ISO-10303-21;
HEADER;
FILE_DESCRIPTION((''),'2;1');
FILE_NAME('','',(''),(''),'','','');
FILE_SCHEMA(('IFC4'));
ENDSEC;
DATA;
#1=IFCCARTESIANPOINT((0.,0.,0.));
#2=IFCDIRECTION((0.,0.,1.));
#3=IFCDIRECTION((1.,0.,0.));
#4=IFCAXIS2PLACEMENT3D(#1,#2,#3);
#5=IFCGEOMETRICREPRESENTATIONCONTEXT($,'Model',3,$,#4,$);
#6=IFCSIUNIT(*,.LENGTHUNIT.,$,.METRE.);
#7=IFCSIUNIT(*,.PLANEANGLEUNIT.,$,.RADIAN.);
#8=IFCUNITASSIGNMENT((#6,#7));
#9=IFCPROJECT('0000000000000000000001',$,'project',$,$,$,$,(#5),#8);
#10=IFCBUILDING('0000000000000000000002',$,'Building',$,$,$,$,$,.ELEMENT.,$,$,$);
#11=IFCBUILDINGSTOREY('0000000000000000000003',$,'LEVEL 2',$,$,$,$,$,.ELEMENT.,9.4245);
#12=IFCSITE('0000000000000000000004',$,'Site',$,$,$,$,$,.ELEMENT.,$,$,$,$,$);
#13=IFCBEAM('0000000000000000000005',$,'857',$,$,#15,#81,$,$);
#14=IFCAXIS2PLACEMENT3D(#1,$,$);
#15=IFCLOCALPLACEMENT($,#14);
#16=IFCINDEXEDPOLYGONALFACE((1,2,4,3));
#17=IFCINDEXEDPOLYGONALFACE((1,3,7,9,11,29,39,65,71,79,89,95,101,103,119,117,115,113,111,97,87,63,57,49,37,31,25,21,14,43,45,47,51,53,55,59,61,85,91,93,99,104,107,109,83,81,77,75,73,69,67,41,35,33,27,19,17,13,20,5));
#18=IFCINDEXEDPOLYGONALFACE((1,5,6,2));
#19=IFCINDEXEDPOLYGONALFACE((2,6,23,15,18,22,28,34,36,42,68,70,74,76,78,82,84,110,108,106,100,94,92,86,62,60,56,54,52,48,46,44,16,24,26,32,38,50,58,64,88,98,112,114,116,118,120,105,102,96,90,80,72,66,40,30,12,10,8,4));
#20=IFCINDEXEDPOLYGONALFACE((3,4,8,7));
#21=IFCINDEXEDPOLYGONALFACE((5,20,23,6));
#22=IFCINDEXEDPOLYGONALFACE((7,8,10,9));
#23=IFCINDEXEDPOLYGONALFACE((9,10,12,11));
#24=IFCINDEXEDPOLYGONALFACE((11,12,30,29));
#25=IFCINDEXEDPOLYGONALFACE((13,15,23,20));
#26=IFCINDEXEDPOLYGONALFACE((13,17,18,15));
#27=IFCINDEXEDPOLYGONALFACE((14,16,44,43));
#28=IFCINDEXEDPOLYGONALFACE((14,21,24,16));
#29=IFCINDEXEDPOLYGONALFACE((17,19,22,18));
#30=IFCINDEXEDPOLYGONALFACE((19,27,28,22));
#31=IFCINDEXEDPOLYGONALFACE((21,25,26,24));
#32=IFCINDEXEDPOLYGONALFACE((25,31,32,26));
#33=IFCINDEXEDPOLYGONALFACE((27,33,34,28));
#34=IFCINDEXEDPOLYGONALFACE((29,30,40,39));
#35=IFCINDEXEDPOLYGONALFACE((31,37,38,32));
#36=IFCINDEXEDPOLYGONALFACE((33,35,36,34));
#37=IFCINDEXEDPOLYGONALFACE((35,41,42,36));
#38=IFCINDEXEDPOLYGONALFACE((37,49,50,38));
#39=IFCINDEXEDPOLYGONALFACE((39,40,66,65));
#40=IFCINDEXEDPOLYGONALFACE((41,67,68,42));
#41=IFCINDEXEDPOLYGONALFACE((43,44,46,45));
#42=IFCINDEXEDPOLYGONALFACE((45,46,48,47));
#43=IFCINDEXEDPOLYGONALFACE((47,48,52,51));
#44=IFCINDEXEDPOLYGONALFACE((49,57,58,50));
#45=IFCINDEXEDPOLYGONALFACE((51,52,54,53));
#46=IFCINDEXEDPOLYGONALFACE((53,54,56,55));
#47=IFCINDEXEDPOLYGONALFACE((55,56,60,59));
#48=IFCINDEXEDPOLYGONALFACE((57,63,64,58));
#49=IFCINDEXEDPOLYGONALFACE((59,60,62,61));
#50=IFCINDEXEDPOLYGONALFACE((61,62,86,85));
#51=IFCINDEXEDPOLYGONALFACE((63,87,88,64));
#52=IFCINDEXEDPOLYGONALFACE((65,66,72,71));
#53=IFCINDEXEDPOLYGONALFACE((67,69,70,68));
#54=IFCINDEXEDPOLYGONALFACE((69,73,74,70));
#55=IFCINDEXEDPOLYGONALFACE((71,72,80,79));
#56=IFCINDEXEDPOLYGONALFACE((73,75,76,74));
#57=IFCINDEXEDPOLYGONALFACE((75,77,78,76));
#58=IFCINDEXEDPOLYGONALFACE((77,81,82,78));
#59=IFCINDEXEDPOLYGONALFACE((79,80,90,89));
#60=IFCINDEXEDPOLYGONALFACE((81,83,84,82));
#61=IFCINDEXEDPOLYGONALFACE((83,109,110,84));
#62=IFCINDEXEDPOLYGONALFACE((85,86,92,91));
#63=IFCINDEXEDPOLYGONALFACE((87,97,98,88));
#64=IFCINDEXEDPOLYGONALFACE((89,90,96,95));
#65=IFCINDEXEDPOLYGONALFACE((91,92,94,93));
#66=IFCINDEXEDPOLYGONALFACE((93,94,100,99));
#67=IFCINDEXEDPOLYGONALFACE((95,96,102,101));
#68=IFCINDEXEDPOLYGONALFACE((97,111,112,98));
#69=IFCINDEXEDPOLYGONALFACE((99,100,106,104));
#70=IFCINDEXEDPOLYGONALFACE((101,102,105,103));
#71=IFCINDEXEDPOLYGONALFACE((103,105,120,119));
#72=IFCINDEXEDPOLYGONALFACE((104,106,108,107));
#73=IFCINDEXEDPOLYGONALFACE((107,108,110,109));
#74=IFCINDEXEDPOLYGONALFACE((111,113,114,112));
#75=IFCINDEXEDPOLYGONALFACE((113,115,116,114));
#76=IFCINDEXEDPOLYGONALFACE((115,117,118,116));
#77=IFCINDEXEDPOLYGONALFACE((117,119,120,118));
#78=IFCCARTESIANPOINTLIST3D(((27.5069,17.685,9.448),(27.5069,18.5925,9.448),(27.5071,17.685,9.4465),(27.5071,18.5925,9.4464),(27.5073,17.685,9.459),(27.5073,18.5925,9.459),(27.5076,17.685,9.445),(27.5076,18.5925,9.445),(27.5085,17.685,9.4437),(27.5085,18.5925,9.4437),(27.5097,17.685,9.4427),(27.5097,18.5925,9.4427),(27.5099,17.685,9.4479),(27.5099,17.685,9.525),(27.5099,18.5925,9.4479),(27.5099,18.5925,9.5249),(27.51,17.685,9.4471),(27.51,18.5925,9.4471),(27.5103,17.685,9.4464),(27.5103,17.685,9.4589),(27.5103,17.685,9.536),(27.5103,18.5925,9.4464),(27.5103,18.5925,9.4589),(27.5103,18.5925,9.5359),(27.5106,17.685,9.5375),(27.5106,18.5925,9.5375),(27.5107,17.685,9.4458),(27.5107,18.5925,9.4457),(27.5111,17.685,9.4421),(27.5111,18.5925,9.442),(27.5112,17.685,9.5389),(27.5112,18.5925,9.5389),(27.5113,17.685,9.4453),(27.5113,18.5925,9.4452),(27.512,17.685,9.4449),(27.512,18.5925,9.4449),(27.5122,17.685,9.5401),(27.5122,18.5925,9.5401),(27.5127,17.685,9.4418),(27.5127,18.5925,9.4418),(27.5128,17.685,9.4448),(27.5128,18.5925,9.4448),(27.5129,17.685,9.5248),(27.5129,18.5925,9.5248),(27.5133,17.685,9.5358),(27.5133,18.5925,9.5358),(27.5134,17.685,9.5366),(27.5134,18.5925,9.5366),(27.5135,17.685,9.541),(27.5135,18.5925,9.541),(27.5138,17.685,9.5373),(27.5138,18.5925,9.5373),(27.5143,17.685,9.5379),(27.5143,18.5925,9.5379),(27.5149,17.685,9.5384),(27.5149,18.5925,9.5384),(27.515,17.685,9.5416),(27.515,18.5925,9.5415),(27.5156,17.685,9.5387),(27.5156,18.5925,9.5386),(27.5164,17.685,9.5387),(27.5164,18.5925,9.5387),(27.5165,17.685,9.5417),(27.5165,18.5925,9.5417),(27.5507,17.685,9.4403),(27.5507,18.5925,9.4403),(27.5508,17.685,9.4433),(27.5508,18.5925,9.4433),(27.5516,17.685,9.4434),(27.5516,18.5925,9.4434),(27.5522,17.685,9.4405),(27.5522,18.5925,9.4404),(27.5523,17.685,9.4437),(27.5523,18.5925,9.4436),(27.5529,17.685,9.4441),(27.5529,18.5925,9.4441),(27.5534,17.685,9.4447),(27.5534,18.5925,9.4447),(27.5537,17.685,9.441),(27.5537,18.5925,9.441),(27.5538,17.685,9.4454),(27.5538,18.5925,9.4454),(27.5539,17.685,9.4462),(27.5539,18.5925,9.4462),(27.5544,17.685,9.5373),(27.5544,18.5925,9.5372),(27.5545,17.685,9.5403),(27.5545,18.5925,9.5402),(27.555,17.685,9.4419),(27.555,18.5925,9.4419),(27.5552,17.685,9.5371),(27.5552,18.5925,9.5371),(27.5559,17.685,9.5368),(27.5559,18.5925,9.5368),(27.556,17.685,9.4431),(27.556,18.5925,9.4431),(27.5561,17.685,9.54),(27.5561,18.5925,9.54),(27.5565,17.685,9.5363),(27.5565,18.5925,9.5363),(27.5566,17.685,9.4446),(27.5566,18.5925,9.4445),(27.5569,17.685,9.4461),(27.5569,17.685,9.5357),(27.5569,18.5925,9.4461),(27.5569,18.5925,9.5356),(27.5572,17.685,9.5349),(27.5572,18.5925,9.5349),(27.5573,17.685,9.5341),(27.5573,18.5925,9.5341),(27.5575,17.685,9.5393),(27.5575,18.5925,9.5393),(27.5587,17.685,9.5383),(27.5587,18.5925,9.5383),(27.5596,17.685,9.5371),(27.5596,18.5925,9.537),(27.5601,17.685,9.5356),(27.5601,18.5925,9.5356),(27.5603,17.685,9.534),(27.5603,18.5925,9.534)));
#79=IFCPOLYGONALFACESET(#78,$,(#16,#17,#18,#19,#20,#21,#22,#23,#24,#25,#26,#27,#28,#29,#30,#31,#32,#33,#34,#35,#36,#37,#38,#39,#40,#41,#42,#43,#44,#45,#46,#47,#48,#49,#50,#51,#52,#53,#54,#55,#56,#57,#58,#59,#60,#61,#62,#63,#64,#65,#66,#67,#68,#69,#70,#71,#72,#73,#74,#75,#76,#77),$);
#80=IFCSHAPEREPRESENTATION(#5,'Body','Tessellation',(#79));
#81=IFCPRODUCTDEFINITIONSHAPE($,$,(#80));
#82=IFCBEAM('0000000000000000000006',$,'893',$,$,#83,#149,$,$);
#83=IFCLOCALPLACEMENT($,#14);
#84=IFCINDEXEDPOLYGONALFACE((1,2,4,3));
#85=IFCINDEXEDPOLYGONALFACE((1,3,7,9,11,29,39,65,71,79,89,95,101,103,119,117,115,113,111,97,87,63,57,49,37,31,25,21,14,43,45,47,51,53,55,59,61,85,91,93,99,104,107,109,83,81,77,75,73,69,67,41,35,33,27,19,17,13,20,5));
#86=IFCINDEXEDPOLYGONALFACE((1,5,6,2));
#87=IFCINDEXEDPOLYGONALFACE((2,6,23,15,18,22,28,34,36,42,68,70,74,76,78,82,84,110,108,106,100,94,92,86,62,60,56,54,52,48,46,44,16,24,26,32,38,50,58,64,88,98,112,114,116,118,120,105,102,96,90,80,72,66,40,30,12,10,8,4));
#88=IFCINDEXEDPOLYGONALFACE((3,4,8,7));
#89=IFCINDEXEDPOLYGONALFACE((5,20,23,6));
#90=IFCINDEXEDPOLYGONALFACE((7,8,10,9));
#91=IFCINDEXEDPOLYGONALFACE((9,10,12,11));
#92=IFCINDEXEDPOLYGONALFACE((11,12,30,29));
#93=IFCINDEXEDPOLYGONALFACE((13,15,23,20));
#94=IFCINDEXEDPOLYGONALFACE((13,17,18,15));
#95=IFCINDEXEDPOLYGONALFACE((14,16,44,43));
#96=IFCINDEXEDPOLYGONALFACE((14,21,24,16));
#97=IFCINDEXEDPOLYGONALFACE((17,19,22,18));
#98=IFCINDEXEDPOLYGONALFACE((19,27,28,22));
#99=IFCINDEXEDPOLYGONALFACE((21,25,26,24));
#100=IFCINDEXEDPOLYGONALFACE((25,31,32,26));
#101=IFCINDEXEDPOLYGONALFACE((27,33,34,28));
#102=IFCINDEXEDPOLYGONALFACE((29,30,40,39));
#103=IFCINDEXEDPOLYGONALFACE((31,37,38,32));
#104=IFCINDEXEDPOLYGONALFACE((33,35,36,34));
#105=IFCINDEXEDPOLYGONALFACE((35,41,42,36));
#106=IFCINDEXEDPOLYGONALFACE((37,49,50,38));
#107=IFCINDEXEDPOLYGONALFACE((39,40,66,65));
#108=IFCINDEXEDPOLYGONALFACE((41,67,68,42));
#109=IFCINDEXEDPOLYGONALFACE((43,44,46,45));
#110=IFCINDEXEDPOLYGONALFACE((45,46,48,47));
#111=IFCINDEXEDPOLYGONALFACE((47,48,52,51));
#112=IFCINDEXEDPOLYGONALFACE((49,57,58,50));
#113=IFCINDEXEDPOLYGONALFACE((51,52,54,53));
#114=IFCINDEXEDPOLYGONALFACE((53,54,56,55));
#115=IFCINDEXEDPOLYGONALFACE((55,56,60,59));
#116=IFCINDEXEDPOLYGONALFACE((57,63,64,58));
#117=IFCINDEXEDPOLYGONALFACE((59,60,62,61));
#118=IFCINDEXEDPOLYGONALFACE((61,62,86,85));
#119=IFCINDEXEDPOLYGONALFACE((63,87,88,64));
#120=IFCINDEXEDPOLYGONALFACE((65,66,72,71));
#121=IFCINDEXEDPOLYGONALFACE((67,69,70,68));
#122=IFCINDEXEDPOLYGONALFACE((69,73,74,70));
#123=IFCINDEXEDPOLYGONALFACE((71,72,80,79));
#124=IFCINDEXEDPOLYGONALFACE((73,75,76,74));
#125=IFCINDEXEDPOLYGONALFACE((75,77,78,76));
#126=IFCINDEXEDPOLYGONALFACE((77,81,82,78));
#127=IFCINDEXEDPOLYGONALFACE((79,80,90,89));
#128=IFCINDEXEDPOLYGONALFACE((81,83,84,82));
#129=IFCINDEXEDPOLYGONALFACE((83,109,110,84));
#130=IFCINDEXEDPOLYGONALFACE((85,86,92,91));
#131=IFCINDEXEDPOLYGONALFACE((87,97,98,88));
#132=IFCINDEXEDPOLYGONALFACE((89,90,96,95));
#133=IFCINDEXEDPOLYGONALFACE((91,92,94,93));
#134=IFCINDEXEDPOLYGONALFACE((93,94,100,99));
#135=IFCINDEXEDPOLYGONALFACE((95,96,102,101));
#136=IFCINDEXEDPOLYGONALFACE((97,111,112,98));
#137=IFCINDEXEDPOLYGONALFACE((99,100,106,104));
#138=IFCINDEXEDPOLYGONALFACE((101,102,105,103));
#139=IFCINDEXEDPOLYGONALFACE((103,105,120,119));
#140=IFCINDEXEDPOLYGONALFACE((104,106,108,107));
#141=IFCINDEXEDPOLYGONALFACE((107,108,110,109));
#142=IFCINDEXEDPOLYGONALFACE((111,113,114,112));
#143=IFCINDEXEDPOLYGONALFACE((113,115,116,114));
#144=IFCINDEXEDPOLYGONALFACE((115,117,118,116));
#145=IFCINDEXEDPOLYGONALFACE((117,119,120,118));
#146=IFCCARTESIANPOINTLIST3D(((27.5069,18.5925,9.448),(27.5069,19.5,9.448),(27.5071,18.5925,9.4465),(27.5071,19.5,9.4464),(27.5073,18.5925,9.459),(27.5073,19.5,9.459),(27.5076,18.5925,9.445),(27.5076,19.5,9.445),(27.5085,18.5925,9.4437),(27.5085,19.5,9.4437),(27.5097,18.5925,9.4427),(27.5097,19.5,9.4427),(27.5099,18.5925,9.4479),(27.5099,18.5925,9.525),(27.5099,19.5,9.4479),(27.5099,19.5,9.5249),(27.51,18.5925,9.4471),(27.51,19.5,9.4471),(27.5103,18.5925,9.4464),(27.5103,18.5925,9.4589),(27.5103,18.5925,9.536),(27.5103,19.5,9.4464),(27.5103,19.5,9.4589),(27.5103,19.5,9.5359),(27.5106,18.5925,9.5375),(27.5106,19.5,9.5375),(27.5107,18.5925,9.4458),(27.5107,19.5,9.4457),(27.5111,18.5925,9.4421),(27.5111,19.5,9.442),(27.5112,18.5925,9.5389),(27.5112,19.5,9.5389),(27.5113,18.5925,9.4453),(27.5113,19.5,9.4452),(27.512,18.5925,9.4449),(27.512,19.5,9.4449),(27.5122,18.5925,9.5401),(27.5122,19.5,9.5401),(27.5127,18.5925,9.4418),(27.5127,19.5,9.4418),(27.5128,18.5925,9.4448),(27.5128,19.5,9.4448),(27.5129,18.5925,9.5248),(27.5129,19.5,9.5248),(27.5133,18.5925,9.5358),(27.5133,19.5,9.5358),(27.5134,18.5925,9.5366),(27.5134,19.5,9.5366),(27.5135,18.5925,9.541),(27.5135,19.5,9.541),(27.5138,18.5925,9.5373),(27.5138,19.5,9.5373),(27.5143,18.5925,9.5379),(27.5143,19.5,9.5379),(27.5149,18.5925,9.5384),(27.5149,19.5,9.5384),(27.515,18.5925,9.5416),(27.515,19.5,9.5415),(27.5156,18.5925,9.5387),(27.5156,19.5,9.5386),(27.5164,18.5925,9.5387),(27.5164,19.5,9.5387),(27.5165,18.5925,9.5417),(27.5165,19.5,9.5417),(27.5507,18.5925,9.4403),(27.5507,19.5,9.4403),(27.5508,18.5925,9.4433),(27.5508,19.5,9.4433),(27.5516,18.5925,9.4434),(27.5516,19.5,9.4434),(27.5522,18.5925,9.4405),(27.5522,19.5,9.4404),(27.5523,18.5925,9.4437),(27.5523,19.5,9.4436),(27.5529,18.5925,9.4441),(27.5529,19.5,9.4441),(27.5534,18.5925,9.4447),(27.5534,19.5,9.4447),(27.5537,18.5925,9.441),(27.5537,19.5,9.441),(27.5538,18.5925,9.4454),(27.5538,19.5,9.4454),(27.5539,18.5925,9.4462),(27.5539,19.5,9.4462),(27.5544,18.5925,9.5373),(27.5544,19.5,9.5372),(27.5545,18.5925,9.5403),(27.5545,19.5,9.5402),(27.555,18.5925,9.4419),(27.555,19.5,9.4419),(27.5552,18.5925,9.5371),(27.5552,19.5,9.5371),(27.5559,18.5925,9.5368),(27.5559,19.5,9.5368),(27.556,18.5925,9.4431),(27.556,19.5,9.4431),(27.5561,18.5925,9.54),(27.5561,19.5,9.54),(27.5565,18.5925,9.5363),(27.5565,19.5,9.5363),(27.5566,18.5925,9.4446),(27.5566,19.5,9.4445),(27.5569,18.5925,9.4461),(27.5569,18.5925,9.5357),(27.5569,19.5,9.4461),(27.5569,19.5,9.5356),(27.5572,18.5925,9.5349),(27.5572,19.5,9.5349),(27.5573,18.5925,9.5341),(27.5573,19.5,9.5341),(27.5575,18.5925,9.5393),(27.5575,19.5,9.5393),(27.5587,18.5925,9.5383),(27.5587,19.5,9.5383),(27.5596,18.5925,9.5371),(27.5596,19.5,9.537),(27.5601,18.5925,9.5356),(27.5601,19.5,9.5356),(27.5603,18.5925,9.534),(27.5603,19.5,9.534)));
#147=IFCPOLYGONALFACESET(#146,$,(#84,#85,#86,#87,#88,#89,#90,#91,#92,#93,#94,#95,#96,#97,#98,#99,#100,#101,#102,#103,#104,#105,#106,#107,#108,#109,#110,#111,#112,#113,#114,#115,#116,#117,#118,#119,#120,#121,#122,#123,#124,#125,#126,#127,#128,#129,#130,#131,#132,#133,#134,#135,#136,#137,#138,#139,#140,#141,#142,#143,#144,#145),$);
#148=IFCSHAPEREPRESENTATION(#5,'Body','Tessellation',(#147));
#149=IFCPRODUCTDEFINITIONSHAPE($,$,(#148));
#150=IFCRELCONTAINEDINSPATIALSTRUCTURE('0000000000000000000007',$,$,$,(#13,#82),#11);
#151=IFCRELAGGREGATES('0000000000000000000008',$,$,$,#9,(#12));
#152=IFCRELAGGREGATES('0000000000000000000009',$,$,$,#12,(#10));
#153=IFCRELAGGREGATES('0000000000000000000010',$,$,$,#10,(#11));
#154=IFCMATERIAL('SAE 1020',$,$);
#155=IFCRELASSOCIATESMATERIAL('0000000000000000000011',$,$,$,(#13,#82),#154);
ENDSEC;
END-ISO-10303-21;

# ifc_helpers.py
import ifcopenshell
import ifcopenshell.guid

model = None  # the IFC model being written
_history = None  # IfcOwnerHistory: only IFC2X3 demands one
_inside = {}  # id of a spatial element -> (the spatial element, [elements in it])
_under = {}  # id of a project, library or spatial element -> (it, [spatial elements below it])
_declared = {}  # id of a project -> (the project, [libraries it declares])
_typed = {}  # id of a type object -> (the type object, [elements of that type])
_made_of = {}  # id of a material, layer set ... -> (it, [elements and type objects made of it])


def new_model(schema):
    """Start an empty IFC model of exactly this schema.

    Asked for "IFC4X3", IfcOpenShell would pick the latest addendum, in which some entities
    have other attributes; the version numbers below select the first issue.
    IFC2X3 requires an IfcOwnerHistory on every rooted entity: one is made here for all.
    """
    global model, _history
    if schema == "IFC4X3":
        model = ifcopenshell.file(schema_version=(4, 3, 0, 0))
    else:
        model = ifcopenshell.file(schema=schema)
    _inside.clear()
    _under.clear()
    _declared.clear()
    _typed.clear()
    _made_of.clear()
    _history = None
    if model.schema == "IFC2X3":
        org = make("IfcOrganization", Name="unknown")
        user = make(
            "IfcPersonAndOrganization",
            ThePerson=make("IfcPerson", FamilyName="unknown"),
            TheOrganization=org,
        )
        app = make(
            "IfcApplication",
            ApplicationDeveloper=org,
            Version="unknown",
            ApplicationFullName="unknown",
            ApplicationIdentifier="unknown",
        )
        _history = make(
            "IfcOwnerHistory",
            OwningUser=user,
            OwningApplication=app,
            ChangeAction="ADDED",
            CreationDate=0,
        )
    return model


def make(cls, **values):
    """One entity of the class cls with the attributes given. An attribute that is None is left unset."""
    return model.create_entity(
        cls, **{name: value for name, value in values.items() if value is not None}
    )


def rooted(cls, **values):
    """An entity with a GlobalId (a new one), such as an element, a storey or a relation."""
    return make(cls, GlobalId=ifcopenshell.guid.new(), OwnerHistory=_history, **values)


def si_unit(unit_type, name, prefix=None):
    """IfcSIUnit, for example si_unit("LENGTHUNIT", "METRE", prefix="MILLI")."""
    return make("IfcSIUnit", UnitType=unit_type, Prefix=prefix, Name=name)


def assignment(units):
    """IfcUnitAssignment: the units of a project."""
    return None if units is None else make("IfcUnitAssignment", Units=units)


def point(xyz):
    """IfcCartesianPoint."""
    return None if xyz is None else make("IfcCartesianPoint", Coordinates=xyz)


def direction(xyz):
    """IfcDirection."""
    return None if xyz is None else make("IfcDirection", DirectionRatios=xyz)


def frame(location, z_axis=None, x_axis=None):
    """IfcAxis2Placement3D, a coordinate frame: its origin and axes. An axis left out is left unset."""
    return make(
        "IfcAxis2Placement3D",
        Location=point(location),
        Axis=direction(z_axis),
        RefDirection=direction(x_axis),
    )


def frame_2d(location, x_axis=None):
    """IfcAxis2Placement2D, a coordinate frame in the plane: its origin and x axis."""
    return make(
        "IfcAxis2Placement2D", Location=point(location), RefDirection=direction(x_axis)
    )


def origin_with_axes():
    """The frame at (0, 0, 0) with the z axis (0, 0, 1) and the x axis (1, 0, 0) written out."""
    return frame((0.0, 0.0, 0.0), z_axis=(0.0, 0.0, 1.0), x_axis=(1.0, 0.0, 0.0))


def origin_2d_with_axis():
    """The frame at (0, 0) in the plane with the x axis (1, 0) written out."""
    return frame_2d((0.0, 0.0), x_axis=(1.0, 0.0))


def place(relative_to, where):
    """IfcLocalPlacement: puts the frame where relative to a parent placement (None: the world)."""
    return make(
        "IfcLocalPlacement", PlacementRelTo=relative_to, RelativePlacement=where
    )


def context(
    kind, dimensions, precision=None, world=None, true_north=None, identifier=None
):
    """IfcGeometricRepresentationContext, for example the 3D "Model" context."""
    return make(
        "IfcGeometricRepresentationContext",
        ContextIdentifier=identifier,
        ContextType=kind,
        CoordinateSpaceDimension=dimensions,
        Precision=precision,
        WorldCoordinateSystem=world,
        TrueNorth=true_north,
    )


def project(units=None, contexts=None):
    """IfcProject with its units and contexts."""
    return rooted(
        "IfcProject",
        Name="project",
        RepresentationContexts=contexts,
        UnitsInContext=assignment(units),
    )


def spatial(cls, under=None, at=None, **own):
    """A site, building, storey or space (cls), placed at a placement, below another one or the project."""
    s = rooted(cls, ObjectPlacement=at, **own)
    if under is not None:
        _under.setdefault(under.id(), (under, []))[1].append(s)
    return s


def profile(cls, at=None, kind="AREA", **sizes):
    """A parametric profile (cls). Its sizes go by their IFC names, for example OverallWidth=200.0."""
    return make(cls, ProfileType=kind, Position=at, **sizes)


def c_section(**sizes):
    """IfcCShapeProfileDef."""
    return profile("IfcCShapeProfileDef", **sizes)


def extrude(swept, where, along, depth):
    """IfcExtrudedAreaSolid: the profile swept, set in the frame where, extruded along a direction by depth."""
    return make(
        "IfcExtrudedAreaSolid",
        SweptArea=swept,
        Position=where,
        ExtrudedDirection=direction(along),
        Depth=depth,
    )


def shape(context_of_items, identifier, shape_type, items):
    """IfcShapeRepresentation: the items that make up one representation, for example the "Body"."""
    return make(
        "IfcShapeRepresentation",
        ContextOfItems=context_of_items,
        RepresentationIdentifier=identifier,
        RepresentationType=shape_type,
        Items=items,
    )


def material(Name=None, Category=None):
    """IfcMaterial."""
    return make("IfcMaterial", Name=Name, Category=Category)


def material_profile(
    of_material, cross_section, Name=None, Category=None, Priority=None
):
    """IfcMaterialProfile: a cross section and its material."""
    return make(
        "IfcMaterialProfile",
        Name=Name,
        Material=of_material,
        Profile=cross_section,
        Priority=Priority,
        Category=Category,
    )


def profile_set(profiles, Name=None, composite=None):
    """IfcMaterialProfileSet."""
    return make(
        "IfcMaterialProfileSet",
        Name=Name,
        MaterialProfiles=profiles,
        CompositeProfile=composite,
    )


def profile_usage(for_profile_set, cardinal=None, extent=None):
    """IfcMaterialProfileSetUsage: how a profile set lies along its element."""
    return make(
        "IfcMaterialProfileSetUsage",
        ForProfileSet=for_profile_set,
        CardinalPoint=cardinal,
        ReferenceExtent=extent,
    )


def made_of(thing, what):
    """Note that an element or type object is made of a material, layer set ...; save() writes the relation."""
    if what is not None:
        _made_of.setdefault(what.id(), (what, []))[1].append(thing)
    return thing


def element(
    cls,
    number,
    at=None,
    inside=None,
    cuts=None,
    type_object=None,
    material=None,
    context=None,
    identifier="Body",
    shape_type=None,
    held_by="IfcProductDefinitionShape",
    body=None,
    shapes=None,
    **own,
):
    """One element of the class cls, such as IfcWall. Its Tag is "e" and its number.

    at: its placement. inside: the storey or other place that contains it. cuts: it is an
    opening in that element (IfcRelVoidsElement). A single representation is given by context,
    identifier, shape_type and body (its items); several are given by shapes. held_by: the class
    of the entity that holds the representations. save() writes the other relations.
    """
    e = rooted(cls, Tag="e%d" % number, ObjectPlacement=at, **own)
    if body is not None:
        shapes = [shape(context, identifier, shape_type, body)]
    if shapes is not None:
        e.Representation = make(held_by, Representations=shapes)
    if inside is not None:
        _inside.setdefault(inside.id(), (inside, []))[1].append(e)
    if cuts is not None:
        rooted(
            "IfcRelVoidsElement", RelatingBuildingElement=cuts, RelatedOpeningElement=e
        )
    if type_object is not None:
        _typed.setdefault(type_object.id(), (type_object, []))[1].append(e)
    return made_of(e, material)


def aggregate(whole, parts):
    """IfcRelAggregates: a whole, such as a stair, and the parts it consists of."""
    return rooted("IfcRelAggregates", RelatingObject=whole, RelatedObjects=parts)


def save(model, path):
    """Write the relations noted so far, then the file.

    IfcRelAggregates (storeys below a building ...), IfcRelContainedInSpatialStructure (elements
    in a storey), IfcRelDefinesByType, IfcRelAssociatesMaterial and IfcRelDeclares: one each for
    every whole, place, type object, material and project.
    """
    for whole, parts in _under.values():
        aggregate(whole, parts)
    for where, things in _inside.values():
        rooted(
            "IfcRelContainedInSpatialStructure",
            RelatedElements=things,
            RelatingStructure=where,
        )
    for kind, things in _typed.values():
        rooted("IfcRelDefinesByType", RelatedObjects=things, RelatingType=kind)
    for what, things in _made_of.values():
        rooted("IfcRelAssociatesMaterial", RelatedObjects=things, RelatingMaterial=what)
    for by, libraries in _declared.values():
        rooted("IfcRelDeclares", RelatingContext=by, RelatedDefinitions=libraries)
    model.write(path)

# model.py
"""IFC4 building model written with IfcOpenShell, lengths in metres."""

from ifc_helpers import new_model, si_unit, frame, origin_with_axes, origin_2d_with_axis, place, context, project, spatial, c_section, extrude, material, material_profile, profile_set, profile_usage, element, save


model = new_model("IFC4")

# Units and contexts
model_context = context("Model", 3, world=origin_with_axes())
ifc_project = project(units=[si_unit("LENGTHUNIT", "METRE"), si_unit("PLANEANGLEUNIT", "RADIAN")], contexts=[model_context])

# Site, building, storey
site = spatial("IfcSite", under=ifc_project, Name="Site", CompositionType="ELEMENT")
building = spatial("IfcBuilding", under=site, Name="Building", CompositionType="ELEMENT")
storey = spatial("IfcBuildingStorey", under=building, Name="LEVEL 2", CompositionType="ELEMENT", Elevation=9.4245)

# Beams
ifc_material = material(Name="SAE 1020")
ifc_material_profile_1 = material_profile(ifc_material, c_section(Depth=0.1, Width=0.05, WallThickness=0.003, Girth=0.017, InternalFilletRadius=0.003, at=origin_2d_with_axis()))
ifc_profile_set_1 = profile_set([ifc_material_profile_1])
ifc_profile_usage_1 = profile_usage(ifc_profile_set_1, cardinal=10)
beam_1_placement = place(None, frame((27.5336, 17.685, 9.491), z_axis=(0.0, 1.0, -0.00003), x_axis=(-0.999256, 0.000001, 0.038562)))
element("IfcBeam", 1, at=beam_1_placement, inside=storey, material=ifc_profile_usage_1, Name="857", context=model_context, shape_type="SweptSolid", body=[
    extrude(c_section(Depth=0.1, Width=0.05, WallThickness=0.003, Girth=0.017, InternalFilletRadius=0.003, at=origin_2d_with_axis()), origin_with_axes(), (0.0, 0.0, 1.0), 0.9075),
])
ifc_material_profile_2 = material_profile(ifc_material, c_section(Depth=0.1, Width=0.05, WallThickness=0.003, Girth=0.017, InternalFilletRadius=0.003, at=origin_2d_with_axis()))
ifc_profile_set_2 = profile_set([ifc_material_profile_2])
ifc_profile_usage_2 = profile_usage(ifc_profile_set_2, cardinal=10)
beam_2_placement = place(None, frame((27.5336, 18.5925, 9.491), z_axis=(0.0, 1.0, -0.00003), x_axis=(-0.999256, 0.000001, 0.038562)))
element("IfcBeam", 2, at=beam_2_placement, inside=storey, material=ifc_profile_usage_2, Name="893", context=model_context, shape_type="SweptSolid", body=[
    extrude(c_section(Depth=0.1, Width=0.05, WallThickness=0.003, Girth=0.017, InternalFilletRadius=0.003, at=origin_2d_with_axis()), origin_with_axes(), (0.0, 0.0, 1.0), 0.9075),
])

save(model, "model.ifc")
